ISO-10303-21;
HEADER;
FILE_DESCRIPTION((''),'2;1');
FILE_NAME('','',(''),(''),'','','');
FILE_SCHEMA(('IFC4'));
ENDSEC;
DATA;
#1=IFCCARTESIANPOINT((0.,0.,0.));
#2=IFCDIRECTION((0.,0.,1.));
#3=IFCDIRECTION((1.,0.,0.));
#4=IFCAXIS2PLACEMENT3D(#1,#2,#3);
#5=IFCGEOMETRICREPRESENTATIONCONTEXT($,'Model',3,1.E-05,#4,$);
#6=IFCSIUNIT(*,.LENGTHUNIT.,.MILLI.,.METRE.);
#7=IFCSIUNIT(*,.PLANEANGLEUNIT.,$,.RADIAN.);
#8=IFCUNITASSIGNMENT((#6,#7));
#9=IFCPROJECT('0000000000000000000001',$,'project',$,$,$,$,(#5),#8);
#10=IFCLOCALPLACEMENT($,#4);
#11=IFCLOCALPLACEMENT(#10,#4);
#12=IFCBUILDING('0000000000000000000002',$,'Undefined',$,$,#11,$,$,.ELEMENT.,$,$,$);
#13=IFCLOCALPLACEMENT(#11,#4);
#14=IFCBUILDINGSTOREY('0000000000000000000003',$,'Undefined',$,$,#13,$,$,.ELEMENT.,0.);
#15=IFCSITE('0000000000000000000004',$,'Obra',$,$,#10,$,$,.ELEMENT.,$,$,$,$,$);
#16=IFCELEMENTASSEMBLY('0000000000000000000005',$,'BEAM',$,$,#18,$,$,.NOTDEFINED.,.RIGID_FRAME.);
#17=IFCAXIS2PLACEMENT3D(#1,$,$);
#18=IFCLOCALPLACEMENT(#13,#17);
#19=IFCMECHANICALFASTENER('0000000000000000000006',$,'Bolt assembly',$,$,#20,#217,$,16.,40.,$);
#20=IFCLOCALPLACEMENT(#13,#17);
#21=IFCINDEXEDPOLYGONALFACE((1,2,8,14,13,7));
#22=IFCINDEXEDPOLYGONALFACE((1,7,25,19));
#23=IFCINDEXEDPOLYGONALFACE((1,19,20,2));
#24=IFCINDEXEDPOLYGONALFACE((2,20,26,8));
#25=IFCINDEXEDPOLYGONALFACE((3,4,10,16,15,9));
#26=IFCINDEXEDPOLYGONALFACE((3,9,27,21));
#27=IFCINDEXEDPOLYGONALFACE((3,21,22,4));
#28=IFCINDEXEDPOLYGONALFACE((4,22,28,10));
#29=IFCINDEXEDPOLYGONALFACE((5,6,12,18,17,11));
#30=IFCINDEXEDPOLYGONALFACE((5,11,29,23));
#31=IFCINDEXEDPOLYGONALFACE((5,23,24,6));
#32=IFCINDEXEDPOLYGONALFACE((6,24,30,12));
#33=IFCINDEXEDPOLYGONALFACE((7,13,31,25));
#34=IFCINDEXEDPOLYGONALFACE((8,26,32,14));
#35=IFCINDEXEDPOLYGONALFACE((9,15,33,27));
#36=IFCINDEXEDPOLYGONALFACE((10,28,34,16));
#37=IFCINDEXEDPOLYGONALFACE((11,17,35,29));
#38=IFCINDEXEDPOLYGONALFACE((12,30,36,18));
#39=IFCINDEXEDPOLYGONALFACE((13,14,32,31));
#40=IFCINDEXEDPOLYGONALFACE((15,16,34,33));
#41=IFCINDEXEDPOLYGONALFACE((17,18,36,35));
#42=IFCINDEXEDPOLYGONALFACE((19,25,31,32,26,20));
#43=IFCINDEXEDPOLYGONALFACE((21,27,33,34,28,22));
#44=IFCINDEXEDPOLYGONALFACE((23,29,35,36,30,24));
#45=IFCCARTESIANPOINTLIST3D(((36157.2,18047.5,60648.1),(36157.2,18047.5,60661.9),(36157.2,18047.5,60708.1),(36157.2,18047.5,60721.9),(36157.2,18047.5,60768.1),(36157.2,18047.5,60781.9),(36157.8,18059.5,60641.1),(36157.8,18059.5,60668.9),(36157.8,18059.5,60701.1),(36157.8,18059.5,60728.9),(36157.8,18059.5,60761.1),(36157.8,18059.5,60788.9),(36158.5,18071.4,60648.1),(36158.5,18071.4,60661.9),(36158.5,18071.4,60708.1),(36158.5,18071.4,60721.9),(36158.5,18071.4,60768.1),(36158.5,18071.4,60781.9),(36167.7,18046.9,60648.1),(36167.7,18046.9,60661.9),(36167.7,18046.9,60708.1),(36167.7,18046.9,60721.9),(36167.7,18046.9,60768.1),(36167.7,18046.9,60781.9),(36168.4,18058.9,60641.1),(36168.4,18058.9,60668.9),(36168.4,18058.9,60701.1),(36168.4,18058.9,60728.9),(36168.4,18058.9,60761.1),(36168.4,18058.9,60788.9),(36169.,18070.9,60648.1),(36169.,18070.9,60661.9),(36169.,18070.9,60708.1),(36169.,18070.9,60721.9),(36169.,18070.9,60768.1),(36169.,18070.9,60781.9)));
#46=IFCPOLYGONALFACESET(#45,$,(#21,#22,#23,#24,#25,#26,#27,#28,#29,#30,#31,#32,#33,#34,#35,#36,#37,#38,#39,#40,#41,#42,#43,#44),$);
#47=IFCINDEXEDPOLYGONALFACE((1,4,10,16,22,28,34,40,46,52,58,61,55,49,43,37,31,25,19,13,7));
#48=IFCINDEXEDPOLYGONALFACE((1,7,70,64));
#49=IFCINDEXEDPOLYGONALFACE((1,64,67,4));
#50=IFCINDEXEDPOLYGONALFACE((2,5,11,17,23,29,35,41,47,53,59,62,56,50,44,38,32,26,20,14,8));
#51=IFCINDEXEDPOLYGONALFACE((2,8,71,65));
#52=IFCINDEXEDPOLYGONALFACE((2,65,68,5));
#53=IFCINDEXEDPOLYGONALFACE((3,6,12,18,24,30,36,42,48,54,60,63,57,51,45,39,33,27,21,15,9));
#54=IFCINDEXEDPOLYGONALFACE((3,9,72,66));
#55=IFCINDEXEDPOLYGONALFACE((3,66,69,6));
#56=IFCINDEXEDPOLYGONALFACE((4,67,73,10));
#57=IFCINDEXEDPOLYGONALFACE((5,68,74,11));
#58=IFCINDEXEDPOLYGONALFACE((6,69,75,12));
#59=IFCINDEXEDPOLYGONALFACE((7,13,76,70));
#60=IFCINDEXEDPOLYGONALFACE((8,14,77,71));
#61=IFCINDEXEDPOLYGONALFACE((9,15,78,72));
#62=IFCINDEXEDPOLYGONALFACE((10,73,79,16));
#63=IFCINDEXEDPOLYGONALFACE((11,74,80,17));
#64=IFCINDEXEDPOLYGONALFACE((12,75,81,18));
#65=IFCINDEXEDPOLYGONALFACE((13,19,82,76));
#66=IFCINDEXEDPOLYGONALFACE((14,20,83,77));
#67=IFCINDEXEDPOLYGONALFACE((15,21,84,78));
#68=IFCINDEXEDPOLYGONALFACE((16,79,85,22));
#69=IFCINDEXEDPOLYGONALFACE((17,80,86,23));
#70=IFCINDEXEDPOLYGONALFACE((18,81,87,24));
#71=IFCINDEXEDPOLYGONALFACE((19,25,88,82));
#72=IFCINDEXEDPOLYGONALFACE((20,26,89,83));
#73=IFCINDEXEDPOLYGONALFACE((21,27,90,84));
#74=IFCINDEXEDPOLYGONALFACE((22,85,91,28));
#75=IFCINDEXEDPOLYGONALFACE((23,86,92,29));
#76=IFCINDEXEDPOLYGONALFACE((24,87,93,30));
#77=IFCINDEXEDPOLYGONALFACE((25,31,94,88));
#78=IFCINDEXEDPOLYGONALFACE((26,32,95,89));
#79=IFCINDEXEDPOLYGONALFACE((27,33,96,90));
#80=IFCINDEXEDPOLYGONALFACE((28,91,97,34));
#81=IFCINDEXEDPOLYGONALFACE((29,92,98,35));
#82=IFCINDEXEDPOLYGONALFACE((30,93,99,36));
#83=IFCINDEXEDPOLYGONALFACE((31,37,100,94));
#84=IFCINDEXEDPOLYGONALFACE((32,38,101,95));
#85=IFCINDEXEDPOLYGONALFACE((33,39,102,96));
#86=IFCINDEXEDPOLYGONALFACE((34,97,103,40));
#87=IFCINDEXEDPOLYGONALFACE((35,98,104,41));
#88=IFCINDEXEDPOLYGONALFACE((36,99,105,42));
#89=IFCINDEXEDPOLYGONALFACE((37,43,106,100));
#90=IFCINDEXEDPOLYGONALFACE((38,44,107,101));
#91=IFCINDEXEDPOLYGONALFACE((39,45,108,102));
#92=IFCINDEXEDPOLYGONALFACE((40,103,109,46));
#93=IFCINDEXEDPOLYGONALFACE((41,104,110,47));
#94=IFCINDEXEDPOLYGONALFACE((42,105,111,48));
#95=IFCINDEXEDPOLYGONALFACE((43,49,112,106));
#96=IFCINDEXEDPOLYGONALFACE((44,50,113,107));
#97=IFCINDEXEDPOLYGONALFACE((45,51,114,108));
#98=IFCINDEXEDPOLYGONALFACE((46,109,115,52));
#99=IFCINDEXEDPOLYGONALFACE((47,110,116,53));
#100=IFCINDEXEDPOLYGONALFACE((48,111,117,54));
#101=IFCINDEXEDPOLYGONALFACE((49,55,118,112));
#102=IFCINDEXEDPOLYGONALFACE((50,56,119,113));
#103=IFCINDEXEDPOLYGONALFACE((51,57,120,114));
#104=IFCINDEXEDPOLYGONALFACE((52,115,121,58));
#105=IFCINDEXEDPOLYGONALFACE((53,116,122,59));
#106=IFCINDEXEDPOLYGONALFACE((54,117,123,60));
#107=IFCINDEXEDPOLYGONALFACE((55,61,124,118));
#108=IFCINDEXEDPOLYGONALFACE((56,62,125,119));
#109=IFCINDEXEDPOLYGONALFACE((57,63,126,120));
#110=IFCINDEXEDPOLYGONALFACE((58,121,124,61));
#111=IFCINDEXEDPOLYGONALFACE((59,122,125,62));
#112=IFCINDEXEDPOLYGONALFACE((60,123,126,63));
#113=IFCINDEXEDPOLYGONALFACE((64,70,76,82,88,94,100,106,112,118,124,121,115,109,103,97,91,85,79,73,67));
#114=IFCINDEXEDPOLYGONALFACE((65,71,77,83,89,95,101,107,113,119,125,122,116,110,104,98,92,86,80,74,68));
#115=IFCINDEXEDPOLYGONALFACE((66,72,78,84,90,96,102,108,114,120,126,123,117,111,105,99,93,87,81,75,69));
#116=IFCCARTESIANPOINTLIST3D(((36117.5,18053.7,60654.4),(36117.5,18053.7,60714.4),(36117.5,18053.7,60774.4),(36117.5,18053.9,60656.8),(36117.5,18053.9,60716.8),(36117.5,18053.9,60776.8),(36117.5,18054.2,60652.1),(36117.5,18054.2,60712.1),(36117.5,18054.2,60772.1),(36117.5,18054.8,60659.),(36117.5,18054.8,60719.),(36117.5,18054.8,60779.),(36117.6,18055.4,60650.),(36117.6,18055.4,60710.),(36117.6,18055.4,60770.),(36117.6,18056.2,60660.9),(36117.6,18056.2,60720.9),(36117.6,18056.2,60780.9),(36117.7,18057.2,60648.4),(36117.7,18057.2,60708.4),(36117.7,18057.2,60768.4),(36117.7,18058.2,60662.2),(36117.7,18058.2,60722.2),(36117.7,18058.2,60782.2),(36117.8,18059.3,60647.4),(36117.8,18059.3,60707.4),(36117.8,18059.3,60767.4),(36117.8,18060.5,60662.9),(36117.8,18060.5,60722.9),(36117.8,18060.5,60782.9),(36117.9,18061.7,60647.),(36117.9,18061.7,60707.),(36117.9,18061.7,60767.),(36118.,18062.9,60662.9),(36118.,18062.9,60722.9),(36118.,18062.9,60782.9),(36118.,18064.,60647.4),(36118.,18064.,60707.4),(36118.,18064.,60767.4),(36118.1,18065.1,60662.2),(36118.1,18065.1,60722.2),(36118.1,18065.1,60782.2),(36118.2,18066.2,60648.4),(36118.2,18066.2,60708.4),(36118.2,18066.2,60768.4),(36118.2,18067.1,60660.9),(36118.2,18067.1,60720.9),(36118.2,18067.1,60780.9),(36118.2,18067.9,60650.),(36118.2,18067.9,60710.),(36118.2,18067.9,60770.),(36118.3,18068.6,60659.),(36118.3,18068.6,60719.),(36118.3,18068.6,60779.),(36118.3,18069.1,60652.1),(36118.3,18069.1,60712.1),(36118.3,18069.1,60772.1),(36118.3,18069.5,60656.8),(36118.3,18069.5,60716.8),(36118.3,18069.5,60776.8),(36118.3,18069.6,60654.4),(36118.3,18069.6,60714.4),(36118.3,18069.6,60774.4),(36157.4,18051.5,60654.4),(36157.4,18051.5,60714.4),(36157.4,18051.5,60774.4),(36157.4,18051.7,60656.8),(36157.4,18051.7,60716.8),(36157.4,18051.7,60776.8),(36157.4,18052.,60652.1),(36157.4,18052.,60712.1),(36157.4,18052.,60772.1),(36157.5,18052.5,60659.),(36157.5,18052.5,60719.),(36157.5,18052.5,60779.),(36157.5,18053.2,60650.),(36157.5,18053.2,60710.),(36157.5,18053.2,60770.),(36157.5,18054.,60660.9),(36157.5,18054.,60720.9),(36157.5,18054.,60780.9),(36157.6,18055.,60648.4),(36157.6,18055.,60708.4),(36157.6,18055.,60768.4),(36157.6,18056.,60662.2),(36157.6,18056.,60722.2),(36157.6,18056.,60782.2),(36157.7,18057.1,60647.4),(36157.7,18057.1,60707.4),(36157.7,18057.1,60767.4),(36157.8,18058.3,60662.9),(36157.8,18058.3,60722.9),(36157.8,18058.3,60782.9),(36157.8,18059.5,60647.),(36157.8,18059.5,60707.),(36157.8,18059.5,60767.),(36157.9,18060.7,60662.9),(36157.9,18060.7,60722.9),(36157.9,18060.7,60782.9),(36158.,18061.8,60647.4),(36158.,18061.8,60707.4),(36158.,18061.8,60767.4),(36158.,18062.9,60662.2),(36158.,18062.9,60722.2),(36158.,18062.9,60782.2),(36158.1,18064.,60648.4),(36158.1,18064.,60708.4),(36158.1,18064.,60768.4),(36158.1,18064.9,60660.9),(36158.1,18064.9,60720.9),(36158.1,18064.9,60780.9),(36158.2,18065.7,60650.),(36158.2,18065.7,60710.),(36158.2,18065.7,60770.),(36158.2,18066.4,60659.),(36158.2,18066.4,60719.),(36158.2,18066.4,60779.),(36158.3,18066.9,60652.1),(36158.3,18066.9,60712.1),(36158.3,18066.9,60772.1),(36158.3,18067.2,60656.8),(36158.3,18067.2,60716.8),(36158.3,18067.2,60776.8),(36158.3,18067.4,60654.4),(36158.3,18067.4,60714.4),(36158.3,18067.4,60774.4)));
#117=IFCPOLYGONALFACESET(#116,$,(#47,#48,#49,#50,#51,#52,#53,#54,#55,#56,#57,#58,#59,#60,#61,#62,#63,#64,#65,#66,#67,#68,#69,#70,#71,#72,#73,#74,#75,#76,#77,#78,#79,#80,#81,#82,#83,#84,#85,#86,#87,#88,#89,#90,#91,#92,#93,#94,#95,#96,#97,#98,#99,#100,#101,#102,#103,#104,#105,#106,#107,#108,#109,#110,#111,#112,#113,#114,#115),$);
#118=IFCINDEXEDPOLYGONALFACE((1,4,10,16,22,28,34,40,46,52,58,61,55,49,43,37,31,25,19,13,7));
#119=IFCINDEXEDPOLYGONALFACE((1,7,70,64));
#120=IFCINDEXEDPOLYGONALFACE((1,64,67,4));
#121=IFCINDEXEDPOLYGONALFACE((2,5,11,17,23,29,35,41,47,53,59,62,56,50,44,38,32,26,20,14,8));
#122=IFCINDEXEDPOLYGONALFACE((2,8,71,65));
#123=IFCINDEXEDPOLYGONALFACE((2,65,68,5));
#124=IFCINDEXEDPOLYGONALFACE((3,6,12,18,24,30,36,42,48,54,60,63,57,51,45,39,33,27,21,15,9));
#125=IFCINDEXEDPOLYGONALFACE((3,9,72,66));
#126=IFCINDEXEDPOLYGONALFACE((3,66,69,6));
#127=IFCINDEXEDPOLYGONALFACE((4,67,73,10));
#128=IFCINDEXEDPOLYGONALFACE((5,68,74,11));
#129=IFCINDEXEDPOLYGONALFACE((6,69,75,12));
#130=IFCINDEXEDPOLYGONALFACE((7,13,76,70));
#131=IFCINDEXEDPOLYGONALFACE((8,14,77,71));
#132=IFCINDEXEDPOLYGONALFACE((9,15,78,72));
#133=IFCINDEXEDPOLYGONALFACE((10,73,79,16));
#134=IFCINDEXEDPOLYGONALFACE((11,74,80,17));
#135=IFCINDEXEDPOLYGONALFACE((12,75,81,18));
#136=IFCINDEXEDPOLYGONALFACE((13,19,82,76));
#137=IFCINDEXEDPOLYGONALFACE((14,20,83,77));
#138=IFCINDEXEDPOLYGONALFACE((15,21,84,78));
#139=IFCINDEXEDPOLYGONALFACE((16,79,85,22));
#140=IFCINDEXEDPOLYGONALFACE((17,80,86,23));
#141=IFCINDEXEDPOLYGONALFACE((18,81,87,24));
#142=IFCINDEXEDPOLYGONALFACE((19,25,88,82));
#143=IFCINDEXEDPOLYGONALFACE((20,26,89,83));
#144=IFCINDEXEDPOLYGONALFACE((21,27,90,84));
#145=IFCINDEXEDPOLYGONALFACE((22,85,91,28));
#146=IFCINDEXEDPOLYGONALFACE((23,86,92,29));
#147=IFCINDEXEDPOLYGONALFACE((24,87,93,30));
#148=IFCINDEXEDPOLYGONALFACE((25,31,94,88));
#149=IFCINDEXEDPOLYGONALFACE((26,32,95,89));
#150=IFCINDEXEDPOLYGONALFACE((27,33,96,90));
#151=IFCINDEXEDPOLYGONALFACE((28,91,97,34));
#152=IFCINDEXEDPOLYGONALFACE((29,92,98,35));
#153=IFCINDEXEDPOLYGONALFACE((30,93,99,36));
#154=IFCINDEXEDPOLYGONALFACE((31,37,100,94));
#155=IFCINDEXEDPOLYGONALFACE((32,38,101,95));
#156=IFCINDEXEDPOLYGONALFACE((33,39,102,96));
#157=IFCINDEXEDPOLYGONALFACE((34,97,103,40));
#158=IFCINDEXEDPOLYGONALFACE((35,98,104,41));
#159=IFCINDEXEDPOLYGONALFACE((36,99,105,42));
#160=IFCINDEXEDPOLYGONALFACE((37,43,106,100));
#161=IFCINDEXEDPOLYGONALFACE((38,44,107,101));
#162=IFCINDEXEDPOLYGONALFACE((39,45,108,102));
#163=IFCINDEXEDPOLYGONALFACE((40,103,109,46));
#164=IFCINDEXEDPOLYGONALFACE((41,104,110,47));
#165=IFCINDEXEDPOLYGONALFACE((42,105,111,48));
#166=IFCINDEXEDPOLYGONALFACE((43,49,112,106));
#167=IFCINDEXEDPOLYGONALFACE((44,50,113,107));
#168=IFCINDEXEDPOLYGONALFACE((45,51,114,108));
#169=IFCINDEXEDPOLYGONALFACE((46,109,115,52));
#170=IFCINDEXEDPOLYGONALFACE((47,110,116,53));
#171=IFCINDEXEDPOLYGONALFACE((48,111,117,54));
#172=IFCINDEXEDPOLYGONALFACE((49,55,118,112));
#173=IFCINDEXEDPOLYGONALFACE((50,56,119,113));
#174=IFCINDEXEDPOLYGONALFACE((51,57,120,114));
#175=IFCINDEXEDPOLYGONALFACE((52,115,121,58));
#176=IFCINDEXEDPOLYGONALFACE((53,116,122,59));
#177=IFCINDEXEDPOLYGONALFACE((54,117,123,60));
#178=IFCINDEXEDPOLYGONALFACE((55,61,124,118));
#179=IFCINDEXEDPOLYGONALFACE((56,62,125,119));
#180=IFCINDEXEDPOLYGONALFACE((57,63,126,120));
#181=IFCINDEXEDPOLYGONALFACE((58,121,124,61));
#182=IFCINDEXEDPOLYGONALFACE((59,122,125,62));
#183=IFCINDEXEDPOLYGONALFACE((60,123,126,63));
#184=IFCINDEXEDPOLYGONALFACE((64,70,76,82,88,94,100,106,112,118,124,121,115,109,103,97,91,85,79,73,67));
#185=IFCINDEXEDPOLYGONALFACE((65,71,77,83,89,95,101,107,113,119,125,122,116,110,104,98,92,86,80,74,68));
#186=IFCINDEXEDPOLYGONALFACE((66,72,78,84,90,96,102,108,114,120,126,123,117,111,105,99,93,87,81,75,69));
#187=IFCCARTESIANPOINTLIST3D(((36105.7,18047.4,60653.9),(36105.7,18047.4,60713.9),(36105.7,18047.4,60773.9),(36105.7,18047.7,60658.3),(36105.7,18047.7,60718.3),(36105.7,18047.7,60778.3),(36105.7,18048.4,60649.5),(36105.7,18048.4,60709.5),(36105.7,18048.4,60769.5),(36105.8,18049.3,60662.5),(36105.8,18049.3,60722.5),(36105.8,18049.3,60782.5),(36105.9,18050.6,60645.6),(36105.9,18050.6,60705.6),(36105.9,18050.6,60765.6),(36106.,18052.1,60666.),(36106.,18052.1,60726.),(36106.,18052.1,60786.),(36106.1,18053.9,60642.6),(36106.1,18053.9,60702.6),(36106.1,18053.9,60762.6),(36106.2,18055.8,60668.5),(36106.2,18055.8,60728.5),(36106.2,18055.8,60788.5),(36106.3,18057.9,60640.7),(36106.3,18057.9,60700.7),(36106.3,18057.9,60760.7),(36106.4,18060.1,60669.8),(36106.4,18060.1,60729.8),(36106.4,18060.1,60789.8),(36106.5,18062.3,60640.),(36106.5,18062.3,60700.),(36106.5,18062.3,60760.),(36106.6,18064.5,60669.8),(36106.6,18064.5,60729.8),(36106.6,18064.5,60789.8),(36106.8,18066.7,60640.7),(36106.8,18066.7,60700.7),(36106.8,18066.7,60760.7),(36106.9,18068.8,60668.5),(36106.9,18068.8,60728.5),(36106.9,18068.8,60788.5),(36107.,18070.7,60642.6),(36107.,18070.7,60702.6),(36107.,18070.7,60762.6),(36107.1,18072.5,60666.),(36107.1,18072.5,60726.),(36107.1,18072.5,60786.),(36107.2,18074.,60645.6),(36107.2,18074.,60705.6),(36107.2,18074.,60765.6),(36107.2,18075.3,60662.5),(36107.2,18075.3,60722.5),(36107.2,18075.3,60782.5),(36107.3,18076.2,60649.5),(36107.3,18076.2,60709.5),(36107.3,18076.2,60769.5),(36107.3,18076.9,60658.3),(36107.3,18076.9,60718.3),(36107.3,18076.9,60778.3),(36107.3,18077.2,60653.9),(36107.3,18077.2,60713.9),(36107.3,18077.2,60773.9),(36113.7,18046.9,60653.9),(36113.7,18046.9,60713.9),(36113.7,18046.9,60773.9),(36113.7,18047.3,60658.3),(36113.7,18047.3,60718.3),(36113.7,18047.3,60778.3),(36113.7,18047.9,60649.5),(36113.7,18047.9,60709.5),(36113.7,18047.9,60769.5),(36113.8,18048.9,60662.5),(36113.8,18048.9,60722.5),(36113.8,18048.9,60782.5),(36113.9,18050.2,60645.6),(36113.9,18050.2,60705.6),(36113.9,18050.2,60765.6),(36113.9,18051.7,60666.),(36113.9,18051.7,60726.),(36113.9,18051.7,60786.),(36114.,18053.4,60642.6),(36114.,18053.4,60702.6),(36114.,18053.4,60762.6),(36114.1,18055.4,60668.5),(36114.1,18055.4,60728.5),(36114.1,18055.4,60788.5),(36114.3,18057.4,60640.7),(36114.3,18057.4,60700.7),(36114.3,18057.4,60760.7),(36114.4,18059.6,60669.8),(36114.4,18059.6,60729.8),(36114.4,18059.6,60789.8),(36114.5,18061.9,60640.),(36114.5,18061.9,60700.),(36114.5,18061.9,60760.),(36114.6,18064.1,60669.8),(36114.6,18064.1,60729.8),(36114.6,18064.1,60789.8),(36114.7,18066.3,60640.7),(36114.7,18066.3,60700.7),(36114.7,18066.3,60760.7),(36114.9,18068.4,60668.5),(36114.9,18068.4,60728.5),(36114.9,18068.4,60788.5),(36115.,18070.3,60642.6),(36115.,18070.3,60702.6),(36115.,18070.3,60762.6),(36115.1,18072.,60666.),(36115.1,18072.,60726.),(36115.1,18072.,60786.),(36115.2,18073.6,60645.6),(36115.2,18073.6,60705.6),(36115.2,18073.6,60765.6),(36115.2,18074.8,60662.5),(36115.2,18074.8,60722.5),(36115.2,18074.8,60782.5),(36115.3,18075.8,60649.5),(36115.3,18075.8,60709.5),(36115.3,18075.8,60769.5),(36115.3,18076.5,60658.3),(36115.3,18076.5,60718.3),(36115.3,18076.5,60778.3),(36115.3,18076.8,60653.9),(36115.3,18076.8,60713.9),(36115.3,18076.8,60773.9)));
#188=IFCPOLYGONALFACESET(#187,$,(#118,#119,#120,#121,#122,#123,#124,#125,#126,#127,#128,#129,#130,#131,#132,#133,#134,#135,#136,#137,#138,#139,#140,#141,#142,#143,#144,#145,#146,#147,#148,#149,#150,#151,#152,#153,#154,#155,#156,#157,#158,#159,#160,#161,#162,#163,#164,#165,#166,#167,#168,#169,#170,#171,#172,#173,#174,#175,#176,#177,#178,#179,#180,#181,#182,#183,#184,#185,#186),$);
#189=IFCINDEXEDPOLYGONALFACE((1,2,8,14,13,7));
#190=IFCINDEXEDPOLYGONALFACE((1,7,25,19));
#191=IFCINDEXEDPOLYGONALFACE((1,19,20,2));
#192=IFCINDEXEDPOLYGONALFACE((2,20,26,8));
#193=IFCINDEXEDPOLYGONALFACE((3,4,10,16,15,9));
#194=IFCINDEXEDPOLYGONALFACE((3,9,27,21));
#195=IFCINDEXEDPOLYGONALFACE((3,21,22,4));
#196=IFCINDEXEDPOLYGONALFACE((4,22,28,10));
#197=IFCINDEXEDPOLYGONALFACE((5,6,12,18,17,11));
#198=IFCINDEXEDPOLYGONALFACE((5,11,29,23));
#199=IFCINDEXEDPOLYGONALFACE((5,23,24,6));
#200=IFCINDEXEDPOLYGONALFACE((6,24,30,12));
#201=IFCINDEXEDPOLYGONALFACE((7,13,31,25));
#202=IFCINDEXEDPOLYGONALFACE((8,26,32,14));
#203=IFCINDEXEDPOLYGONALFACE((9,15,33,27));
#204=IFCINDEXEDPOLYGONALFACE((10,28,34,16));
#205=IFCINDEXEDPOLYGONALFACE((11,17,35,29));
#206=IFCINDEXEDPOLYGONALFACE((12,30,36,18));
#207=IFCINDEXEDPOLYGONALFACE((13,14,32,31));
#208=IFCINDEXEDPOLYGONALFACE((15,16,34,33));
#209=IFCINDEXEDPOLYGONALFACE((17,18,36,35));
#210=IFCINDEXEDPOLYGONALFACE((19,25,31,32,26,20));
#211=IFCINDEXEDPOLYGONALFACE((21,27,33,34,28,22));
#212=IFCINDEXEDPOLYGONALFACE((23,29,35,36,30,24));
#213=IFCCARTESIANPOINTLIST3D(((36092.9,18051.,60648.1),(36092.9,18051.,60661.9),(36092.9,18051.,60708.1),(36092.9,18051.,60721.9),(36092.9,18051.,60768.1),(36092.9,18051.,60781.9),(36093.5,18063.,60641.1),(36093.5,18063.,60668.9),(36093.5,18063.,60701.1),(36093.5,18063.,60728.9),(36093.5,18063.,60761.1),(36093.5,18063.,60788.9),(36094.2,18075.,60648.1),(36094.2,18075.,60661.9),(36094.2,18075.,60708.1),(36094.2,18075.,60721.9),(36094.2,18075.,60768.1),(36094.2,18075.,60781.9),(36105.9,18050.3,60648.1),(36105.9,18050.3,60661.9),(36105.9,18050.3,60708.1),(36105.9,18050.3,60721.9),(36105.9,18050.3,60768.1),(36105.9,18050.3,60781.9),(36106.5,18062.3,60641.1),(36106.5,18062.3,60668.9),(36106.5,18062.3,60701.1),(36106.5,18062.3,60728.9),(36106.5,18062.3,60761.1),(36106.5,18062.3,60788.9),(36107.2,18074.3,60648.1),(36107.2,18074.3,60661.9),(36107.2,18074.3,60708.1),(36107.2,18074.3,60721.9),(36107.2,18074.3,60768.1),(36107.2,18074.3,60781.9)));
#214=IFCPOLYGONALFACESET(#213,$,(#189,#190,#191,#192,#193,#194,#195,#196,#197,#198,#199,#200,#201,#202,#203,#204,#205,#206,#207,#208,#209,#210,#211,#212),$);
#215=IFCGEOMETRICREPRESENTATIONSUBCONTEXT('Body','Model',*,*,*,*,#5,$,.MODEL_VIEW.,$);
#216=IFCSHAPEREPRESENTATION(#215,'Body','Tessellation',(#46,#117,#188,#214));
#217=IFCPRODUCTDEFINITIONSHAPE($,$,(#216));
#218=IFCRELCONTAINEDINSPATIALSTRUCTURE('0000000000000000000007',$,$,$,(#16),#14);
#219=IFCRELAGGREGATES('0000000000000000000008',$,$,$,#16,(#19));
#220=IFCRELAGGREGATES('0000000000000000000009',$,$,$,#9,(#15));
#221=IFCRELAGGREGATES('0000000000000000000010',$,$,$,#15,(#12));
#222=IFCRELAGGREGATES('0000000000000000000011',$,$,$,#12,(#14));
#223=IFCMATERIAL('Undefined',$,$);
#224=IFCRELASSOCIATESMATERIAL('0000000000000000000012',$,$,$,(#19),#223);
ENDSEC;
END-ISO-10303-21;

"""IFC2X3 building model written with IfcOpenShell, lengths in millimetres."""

from ifc_helpers import new_model, si_unit, frame, origin_with_axes, origin_2d_with_axis, place, context, subcontext, project, spatial, polyline, circle, outline, extrude, source, transform, mapped, material, element, aggregate, save


model = new_model("IFC2X3")

# Units and contexts
model_context = context("Model", 3, precision=1e-05, world=origin_with_axes())
body_context = subcontext(model_context, "Body", "Model", "MODEL_VIEW")
ifc_project = project(units=[si_unit("LENGTHUNIT", "METRE", prefix="MILLI"), si_unit("PLANEANGLEUNIT", "RADIAN")], contexts=[model_context])

# Site, building, storey
site_placement = place(None, origin_with_axes())
site = spatial("IfcSite", under=ifc_project, at=site_placement, Name="Obra", CompositionType="ELEMENT")
building_placement = place(site_placement, origin_with_axes())
building = spatial("IfcBuilding", under=site, at=building_placement, Name="Undefined", CompositionType="ELEMENT")
storey_placement = place(building_placement, origin_with_axes())
storey = spatial("IfcBuildingStorey", under=building, at=storey_placement, Name="Undefined", CompositionType="ELEMENT", Elevation=0.0)

# Element assembly, mechanical fastener
ifc_material_1 = material(Name="Undefined")
shared_shape_1 = source(origin_with_axes(), body_context, "Body", "SweptSolid", [
    extrude(outline(polyline([(13.9, 0.0), (6.9, 12.0), (-6.9, 12.0), (-13.9, 0.0), (-6.9, -12.0), (6.9, -12.0), (13.9, 0.0)])), frame((0.0, -19.7, 0.0), z_axis=(0.0, 1.0, 0.0), x_axis=(1.0, 0.0, 0.0)), (0.0, 0.0, 1.0), 10.6),
    extrude(circle(Radius=8.0, at=origin_2d_with_axis()), frame((0.0, -9.1, 0.0), z_axis=(0.0, 1.0, 0.0), x_axis=(1.0, 0.0, 0.0)), (0.0, 0.0, 1.0), 40.0),
    extrude(circle(Radius=15.0, at=origin_2d_with_axis()), frame((0.0, 34.3, 0.0), z_axis=(0.0, 1.0, 0.0), x_axis=(1.0, 0.0, 0.0)), (0.0, 0.0, 1.0), 8.0),
    extrude(outline(polyline([(13.9, 0.0), (6.9, 12.0), (-6.9, 12.0), (-13.9, 0.0), (-6.9, -12.0), (6.9, -12.0), (13.9, 0.0)])), frame((0.0, 42.3, 0.0), z_axis=(0.0, 1.0, 0.0), x_axis=(1.0, 0.0, 0.0)), (0.0, 0.0, 1.0), 13.0),
])
assembly_1_placement = place(storey_placement, origin_with_axes())
assembly_1 = element("IfcElementAssembly", 1, at=assembly_1_placement, inside=storey, Name="BEAM", AssemblyPlace="NOTDEFINED", PredefinedType="RIGID_FRAME")
mechanical_fastener_1_placement = place(assembly_1_placement, frame((36146.0, 18010.0, 60835.0), z_axis=(0.055268, 0.998472, 0.0), x_axis=(0.0, 0.0, -1.0)))
mechanical_fastener_1 = element("IfcMechanicalFastener", 2, at=mechanical_fastener_1_placement, material=ifc_material_1, Name="Bolt assembly", NominalDiameter=16.0, NominalLength=40.0, context=body_context, shape_type="MappedRepresentation", body=[
    mapped(shared_shape_1, transform((60.0, 0.0, 50.0))),
    mapped(shared_shape_1, transform((120.0, 0.0, 50.0))),
    mapped(shared_shape_1, transform((180.0, 0.0, 50.0))),
])
aggregate(assembly_1, [mechanical_fastener_1])

save(model, "model.ifc")
